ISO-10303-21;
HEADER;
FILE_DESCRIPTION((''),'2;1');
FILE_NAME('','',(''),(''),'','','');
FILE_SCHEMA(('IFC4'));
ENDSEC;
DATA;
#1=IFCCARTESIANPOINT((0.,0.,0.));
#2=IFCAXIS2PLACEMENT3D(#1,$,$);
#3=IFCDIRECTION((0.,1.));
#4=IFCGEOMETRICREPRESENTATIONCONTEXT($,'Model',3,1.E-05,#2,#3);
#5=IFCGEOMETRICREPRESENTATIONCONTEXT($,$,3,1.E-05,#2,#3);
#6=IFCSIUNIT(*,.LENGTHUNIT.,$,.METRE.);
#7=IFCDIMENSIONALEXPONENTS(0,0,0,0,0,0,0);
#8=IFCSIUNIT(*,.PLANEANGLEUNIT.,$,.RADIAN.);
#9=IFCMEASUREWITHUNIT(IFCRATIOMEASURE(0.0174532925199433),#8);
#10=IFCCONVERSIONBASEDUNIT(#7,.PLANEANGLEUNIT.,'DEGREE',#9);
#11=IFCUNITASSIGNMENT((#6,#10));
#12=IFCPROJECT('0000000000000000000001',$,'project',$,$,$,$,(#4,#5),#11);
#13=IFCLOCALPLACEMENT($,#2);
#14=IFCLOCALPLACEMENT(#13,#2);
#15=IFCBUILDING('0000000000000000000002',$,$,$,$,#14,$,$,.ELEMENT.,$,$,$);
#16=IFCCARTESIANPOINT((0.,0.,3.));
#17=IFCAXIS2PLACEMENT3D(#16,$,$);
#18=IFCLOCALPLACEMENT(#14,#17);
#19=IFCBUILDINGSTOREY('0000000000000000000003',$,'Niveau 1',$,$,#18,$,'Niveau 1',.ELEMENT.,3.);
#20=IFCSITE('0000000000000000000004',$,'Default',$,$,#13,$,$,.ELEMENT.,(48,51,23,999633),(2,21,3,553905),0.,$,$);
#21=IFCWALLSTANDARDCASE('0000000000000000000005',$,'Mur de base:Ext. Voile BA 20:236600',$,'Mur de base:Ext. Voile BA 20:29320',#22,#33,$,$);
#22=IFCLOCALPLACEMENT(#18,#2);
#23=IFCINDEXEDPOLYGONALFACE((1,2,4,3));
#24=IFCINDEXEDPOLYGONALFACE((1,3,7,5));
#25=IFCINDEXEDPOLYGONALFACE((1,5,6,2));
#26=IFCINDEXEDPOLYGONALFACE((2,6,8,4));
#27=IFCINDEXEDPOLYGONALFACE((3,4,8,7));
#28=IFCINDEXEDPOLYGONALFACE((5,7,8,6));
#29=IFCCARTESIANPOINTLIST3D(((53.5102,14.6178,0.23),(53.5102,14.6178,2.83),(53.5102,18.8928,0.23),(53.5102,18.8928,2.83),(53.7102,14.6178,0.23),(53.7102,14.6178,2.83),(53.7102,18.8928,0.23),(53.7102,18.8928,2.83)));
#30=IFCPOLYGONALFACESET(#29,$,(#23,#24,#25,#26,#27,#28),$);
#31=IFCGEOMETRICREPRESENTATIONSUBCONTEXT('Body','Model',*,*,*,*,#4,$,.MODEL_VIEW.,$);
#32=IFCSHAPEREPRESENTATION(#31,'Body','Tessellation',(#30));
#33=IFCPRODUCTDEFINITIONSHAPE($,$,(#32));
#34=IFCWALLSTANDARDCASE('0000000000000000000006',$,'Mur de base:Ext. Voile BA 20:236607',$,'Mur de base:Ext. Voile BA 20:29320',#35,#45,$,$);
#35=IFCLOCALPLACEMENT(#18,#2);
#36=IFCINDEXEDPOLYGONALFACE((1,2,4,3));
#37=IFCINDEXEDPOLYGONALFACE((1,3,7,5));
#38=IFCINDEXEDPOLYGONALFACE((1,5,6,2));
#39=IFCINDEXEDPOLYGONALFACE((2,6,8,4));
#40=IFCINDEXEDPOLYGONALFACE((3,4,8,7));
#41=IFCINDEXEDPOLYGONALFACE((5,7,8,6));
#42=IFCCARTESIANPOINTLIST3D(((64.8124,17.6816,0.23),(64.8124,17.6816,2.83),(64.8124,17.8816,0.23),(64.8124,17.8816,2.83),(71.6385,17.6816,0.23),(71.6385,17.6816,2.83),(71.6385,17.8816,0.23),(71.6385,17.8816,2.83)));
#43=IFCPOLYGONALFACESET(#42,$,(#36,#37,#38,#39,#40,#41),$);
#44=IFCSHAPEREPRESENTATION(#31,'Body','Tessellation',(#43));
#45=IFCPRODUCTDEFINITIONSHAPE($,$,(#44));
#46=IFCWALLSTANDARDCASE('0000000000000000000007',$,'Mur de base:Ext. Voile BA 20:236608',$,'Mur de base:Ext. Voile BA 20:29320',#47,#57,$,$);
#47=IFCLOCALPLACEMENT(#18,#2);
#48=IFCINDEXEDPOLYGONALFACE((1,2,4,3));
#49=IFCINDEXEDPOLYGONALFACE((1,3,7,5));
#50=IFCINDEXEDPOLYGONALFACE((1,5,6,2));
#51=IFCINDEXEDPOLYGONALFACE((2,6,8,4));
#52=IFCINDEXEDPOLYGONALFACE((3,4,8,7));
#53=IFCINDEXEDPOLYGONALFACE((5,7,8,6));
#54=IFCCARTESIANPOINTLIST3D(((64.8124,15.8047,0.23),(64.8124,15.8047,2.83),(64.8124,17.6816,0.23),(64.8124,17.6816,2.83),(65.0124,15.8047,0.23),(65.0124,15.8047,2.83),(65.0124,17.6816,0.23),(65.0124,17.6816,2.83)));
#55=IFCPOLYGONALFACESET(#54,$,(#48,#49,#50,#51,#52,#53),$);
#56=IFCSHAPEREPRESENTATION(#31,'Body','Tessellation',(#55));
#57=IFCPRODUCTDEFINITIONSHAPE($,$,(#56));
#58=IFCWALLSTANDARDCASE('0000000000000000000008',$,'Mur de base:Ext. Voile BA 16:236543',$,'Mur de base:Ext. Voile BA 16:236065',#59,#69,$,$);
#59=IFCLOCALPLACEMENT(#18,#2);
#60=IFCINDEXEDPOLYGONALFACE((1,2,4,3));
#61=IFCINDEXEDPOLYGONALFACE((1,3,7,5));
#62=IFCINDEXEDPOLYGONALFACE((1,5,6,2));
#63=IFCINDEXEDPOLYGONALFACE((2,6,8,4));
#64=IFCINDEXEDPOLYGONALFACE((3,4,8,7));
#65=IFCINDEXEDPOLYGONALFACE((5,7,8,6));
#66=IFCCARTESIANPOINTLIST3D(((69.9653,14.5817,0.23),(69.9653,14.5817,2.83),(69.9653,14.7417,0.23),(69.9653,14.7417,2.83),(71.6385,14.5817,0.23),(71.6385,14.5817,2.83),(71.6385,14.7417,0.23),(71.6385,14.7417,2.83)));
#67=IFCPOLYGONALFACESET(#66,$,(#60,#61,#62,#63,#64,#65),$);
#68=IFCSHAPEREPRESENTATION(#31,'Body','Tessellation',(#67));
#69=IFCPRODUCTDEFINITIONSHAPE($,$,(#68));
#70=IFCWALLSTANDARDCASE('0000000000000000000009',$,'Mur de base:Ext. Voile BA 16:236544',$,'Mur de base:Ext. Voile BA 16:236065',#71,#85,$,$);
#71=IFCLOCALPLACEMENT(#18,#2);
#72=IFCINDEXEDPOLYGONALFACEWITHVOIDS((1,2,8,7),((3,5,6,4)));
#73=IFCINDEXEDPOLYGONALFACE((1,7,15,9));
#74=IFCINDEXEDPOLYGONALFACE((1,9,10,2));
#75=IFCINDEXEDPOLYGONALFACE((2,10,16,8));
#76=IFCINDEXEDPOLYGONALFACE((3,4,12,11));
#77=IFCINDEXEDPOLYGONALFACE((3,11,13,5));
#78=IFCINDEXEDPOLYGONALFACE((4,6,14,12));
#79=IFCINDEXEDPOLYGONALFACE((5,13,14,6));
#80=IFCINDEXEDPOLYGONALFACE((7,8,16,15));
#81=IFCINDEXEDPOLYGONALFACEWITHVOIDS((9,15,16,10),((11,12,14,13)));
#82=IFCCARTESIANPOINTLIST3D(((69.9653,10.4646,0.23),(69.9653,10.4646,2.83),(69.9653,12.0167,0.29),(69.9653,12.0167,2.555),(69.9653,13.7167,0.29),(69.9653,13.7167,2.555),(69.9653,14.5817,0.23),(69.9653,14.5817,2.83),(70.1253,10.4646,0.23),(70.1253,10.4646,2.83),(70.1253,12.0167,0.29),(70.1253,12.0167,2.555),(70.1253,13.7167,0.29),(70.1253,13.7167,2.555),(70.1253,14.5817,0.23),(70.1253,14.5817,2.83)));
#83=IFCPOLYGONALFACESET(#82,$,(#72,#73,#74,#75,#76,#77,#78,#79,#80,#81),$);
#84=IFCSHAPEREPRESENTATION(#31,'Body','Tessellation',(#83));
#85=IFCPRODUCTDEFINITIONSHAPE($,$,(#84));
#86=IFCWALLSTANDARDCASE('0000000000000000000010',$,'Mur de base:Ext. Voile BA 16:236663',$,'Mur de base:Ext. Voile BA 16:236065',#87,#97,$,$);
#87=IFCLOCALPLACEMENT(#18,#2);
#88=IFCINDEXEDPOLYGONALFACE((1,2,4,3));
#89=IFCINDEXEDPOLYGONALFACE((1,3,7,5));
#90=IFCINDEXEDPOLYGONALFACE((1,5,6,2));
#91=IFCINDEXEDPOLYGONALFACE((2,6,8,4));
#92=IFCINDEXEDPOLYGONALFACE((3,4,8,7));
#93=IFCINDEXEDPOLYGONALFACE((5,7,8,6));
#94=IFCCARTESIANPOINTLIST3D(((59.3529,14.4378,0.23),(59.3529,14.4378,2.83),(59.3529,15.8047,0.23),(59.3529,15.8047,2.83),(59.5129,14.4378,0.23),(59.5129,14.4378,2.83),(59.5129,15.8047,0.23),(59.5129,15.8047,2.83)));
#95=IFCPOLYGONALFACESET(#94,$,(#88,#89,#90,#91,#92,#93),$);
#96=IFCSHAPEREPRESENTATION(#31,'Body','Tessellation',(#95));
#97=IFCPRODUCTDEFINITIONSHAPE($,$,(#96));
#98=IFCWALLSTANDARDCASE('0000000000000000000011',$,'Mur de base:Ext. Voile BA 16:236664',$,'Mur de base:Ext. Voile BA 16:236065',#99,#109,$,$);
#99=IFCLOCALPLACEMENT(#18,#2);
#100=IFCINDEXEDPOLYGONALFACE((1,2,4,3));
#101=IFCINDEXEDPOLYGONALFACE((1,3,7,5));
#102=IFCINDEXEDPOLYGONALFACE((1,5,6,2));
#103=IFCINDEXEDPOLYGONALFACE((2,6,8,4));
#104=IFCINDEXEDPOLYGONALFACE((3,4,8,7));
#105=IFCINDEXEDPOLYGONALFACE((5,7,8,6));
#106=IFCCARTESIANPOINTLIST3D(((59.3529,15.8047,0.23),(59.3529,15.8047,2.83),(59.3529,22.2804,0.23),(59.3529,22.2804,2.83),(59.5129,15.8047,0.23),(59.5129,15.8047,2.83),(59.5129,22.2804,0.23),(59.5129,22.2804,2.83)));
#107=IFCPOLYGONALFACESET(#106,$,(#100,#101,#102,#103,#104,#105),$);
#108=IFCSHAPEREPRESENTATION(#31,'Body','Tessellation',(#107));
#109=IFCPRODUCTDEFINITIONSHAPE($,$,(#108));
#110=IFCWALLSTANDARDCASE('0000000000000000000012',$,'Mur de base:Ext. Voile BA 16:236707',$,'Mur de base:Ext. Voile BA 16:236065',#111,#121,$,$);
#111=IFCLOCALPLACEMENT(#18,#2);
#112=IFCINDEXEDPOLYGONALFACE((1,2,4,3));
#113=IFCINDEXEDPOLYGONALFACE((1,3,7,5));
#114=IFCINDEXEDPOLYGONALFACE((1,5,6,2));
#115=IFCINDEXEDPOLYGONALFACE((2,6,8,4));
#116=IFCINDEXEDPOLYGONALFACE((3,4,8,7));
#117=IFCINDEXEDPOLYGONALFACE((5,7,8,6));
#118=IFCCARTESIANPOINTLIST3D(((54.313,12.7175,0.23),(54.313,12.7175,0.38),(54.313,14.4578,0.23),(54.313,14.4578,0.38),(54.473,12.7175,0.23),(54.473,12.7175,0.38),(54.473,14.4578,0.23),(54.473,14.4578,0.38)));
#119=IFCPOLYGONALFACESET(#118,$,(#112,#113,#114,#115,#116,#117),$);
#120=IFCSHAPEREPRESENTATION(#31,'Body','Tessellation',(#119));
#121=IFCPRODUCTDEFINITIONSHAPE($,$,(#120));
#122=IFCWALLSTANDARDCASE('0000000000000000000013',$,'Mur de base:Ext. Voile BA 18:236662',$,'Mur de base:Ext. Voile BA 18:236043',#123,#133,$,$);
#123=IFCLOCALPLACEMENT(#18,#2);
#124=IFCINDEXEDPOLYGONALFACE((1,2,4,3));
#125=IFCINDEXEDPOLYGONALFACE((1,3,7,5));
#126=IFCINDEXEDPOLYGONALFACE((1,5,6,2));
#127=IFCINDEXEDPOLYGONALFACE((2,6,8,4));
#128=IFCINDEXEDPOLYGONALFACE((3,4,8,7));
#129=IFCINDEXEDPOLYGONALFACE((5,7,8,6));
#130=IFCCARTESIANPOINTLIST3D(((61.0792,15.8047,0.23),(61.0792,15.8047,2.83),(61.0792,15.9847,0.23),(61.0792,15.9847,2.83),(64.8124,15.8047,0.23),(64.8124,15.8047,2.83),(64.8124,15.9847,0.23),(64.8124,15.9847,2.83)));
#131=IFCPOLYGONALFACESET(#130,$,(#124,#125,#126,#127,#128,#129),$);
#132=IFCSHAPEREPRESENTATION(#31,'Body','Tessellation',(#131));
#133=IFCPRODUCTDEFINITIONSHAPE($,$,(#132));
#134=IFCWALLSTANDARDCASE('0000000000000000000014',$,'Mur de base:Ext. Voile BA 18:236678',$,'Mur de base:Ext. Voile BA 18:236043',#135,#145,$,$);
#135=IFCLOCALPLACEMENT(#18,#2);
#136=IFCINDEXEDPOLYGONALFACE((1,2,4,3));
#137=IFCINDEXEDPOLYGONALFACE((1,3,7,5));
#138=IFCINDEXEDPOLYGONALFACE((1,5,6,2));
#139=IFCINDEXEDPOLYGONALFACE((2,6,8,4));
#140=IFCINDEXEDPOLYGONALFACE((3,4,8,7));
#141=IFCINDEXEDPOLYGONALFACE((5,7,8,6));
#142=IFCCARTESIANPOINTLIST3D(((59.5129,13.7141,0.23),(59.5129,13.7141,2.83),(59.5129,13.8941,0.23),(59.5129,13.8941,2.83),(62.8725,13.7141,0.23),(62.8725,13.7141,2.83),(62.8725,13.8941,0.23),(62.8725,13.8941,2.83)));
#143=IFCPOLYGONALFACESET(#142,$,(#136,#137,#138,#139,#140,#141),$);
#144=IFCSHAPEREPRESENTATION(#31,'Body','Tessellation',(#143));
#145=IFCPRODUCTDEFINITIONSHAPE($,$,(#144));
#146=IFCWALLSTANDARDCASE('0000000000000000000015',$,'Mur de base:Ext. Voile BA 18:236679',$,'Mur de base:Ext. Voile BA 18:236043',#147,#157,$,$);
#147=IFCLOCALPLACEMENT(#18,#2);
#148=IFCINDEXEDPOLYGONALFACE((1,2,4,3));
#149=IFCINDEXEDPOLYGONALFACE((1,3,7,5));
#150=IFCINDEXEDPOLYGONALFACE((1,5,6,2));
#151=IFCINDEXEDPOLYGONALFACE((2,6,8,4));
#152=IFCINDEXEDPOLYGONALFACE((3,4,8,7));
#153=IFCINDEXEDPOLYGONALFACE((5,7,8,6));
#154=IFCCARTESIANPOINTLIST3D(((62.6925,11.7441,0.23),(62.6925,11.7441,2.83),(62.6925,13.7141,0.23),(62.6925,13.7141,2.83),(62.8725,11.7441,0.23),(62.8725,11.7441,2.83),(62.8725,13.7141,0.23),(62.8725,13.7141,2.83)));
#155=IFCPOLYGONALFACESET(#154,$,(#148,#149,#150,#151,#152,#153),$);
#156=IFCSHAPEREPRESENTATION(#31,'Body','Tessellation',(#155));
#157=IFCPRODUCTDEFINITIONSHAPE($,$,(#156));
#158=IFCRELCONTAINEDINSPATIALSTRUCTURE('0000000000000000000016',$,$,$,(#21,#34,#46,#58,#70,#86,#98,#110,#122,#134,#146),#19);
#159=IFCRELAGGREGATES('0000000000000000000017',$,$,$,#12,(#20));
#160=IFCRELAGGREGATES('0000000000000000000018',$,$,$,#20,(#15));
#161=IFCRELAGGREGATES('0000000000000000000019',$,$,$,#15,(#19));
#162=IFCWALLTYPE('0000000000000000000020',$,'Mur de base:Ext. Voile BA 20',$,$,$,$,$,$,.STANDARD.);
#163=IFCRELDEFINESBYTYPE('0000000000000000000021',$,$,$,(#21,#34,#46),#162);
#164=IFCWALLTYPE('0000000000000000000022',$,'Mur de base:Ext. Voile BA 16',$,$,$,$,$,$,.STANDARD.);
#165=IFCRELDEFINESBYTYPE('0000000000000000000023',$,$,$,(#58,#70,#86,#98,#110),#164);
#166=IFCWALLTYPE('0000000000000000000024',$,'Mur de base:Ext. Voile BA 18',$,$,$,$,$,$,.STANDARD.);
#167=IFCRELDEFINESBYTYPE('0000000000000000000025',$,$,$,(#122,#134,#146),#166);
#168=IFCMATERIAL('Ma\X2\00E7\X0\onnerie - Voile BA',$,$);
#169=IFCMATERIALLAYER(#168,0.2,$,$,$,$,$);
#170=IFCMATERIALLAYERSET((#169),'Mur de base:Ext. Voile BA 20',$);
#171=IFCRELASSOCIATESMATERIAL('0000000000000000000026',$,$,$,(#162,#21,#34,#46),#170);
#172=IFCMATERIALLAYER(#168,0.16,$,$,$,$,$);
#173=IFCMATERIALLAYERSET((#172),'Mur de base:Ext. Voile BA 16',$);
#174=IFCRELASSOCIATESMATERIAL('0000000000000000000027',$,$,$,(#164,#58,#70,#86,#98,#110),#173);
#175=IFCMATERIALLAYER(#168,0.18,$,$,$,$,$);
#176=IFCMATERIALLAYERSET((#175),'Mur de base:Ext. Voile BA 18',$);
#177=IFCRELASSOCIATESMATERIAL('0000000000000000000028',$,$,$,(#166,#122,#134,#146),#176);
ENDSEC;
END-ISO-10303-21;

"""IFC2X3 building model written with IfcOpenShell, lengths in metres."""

from ifc_helpers import new_model, entity, si_unit, converted_unit, direction, frame, frame_2d, origin, origin_2d_with_axis, place, context, subcontext, project, spatial, rectangle, extrude, material, layer, layer_set, layer_usage, type_object, element, save


model = new_model("IFC2X3")

# Units and contexts
model_context = context("Model", 3, precision=1e-05, world=origin(), true_north=direction((0.0, 1.0)))
context_of_model = context(None, 3, precision=1e-05, world=origin(), true_north=direction((0.0, 1.0)))
body_context = subcontext(model_context, "Body", "Model", "MODEL_VIEW")
ifc_project = project(units=[si_unit("LENGTHUNIT", "METRE"), converted_unit("PLANEANGLEUNIT", "DEGREE", entity("IfcRatioMeasure", 0.0174532925199433), si_unit("PLANEANGLEUNIT", "RADIAN"), dimensions=[0, 0, 0, 0, 0, 0, 0])], contexts=[model_context, context_of_model])

# Site, building, storey
site_placement = place(None, origin())
site = spatial("IfcSite", under=ifc_project, at=site_placement, Name="Default", CompositionType="ELEMENT", RefLatitude=(48, 51, 23, 999633), RefLongitude=(2, 21, 3, 553905), RefElevation=0.0)
building_placement = place(site_placement, origin())
building = spatial("IfcBuilding", under=site, at=building_placement, CompositionType="ELEMENT")
storey_placement = place(building_placement, frame((0.0, 0.0, 3.0)))
storey = spatial("IfcBuildingStorey", under=building, at=storey_placement, Name="Niveau 1", LongName="Niveau 1", CompositionType="ELEMENT", Elevation=3.0)

# Walls
ifc_material = material(Name="Maçonnerie - Voile BA")
ifc_layer_1 = layer(ifc_material, 0.2)
ifc_layer_set_1 = layer_set([ifc_layer_1], Name="Mur de base:Ext. Voile BA 20")
ifc_layer_usage_1 = layer_usage(ifc_layer_set_1, "AXIS2", "NEGATIVE", 0.1)
wall_type_1 = type_object("IfcWallType", Name="Mur de base:Ext. Voile BA 20", PredefinedType="STANDARD", material=ifc_layer_set_1)
wall_1_placement = place(storey_placement, frame((53.6102, 18.8928, 0.23), z_axis=(0.0, 0.0, 1.0), x_axis=(0.0, -1.0, 0.0)))
element("IfcWallStandardCase", 1, at=wall_1_placement, inside=storey, type_object=wall_type_1, material=ifc_layer_usage_1, Name="Mur de base:Ext. Voile BA 20:236600", ObjectType="Mur de base:Ext. Voile BA 20:29320", context=body_context, shape_type="SweptSolid", body=[
    extrude(rectangle(XDim=4.275, YDim=0.2, at=frame_2d((2.1375, 0.0), x_axis=(-1.0, 0.0))), origin(), (0.0, 0.0, 1.0), 2.6),
])
ifc_layer_usage_2 = layer_usage(ifc_layer_set_1, "AXIS2", "NEGATIVE", 0.1)
wall_2_placement = place(storey_placement, frame((71.6385, 17.7816, 0.23), z_axis=(0.0, 0.0, 1.0), x_axis=(-1.0, 0.0, 0.0)))
element("IfcWallStandardCase", 2, at=wall_2_placement, inside=storey, type_object=wall_type_1, material=ifc_layer_usage_2, Name="Mur de base:Ext. Voile BA 20:236607", ObjectType="Mur de base:Ext. Voile BA 20:29320", context=body_context, shape_type="SweptSolid", body=[
    extrude(rectangle(XDim=6.8261, YDim=0.2, at=frame_2d((3.4131, 0.0), x_axis=(-1.0, 0.0))), origin(), (0.0, 0.0, 1.0), 2.6),
])
ifc_layer_usage_3 = layer_usage(ifc_layer_set_1, "AXIS2", "NEGATIVE", 0.1)
wall_3_placement = place(storey_placement, frame((64.9124, 17.6816, 0.23), z_axis=(0.0, 0.0, 1.0), x_axis=(0.0, -1.0, 0.0)))
element("IfcWallStandardCase", 3, at=wall_3_placement, inside=storey, type_object=wall_type_1, material=ifc_layer_usage_3, Name="Mur de base:Ext. Voile BA 20:236608", ObjectType="Mur de base:Ext. Voile BA 20:29320", context=body_context, shape_type="SweptSolid", body=[
    extrude(rectangle(XDim=1.8769, YDim=0.2, at=frame_2d((0.9384, 0.0), x_axis=(-1.0, 0.0))), origin(), (0.0, 0.0, 1.0), 2.6),
])

# Wall
ifc_layer_2 = layer(ifc_material, 0.16)
ifc_layer_set_2 = layer_set([ifc_layer_2], Name="Mur de base:Ext. Voile BA 16")
ifc_layer_usage_4 = layer_usage(ifc_layer_set_2, "AXIS2", "NEGATIVE", 0.08)
wall_type_2 = type_object("IfcWallType", Name="Mur de base:Ext. Voile BA 16", PredefinedType="STANDARD", material=ifc_layer_set_2)
wall_4_placement = place(storey_placement, frame((71.6385, 14.6617, 0.23), z_axis=(0.0, 0.0, 1.0), x_axis=(-1.0, 0.0, 0.0)))
element("IfcWallStandardCase", 4, at=wall_4_placement, inside=storey, type_object=wall_type_2, material=ifc_layer_usage_4, Name="Mur de base:Ext. Voile BA 16:236543", ObjectType="Mur de base:Ext. Voile BA 16:236065", context=body_context, shape_type="SweptSolid", body=[
    extrude(rectangle(XDim=1.6732, YDim=0.16, at=frame_2d((0.8366, 0.0), x_axis=(-1.0, 0.0))), origin(), (0.0, 0.0, 1.0), 2.6),
])

# Wall, opening
ifc_layer_usage_5 = layer_usage(ifc_layer_set_2, "AXIS2", "NEGATIVE", 0.08)
wall_5_placement = place(storey_placement, frame((70.0453, 14.5817, 0.23), z_axis=(0.0, 0.0, 1.0), x_axis=(0.0, -1.0, 0.0)))
wall_5 = element("IfcWallStandardCase", 5, at=wall_5_placement, inside=storey, type_object=wall_type_2, material=ifc_layer_usage_5, Name="Mur de base:Ext. Voile BA 16:236544", ObjectType="Mur de base:Ext. Voile BA 16:236065", context=body_context, shape_type="SweptSolid", body=[
    extrude(rectangle(XDim=4.117, YDim=0.16, at=frame_2d((2.0585, 0.0), x_axis=(-1.0, 0.0))), origin(), (0.0, 0.0, 1.0), 2.6),
])
opening_1_placement = place(wall_5_placement, origin())
element("IfcOpeningElement", 6, at=opening_1_placement, cuts=wall_5, ObjectType="Opening", context=body_context, shape_type="SweptSolid", body=[
    extrude(rectangle(XDim=2.265, YDim=1.7, at=origin_2d_with_axis()), frame((1.715, -0.08, 1.1925), z_axis=(0.0, 1.0, 0.0), x_axis=(0.0, 0.0, -1.0)), (0.0, 0.0, 1.0), 0.16),
])

# Walls
ifc_layer_usage_6 = layer_usage(ifc_layer_set_2, "AXIS2", "NEGATIVE", 0.08)
wall_6_placement = place(storey_placement, frame((59.4329, 14.4378, 0.23), z_axis=(0.0, 0.0, 1.0), x_axis=(0.0, 1.0, 0.0)))
element("IfcWallStandardCase", 7, at=wall_6_placement, inside=storey, type_object=wall_type_2, material=ifc_layer_usage_6, Name="Mur de base:Ext. Voile BA 16:236663", ObjectType="Mur de base:Ext. Voile BA 16:236065", context=body_context, shape_type="SweptSolid", body=[
    extrude(rectangle(XDim=1.3669, YDim=0.16, at=frame_2d((0.6834, 0.0), x_axis=(-1.0, 0.0))), origin(), (0.0, 0.0, 1.0), 2.6),
])
ifc_layer_usage_7 = layer_usage(ifc_layer_set_2, "AXIS2", "NEGATIVE", 0.08)
wall_7_placement = place(storey_placement, frame((59.4329, 15.8047, 0.23), z_axis=(0.0, 0.0, 1.0), x_axis=(0.0, 1.0, 0.0)))
element("IfcWallStandardCase", 8, at=wall_7_placement, inside=storey, type_object=wall_type_2, material=ifc_layer_usage_7, Name="Mur de base:Ext. Voile BA 16:236664", ObjectType="Mur de base:Ext. Voile BA 16:236065", context=body_context, shape_type="SweptSolid", body=[
    extrude(rectangle(XDim=6.4757, YDim=0.16, at=frame_2d((3.2379, 0.0), x_axis=(-1.0, 0.0))), origin(), (0.0, 0.0, 1.0), 2.6),
])
ifc_layer_usage_8 = layer_usage(ifc_layer_set_2, "AXIS2", "POSITIVE", -0.08)
wall_8_placement = place(storey_placement, frame((54.393, 12.7175, 0.23), z_axis=(0.0, 0.0, 1.0), x_axis=(0.0, 1.0, 0.0)))
element("IfcWallStandardCase", 9, at=wall_8_placement, inside=storey, type_object=wall_type_2, material=ifc_layer_usage_8, Name="Mur de base:Ext. Voile BA 16:236707", ObjectType="Mur de base:Ext. Voile BA 16:236065", context=body_context, shape_type="SweptSolid", body=[
    extrude(rectangle(XDim=1.7403, YDim=0.16, at=frame_2d((0.8702, 0.0), x_axis=(-1.0, 0.0))), origin(), (0.0, 0.0, 1.0), 0.15),
])
ifc_layer_3 = layer(ifc_material, 0.18)
ifc_layer_set_3 = layer_set([ifc_layer_3], Name="Mur de base:Ext. Voile BA 18")
ifc_layer_usage_9 = layer_usage(ifc_layer_set_3, "AXIS2", "POSITIVE", -0.09)
wall_type_3 = type_object("IfcWallType", Name="Mur de base:Ext. Voile BA 18", PredefinedType="STANDARD", material=ifc_layer_set_3)
wall_9_placement = place(storey_placement, frame((61.0792, 15.8947, 0.23)))
element("IfcWallStandardCase", 10, at=wall_9_placement, inside=storey, type_object=wall_type_3, material=ifc_layer_usage_9, Name="Mur de base:Ext. Voile BA 18:236662", ObjectType="Mur de base:Ext. Voile BA 18:236043", context=body_context, shape_type="SweptSolid", body=[
    extrude(rectangle(XDim=3.7331, YDim=0.18, at=frame_2d((1.8666, 0.0), x_axis=(-1.0, 0.0))), origin(), (0.0, 0.0, 1.0), 2.6),
])
ifc_layer_usage_10 = layer_usage(ifc_layer_set_3, "AXIS2", "NEGATIVE", 0.09)
wall_10_placement = place(storey_placement, frame((59.5129, 13.8041, 0.23)))
element("IfcWallStandardCase", 11, at=wall_10_placement, inside=storey, type_object=wall_type_3, material=ifc_layer_usage_10, Name="Mur de base:Ext. Voile BA 18:236678", ObjectType="Mur de base:Ext. Voile BA 18:236043", context=body_context, shape_type="SweptSolid", body=[
    extrude(rectangle(XDim=3.3596, YDim=0.18, at=frame_2d((1.6798, 0.0), x_axis=(-1.0, 0.0))), origin(), (0.0, 0.0, 1.0), 2.6),
])
ifc_layer_usage_11 = layer_usage(ifc_layer_set_3, "AXIS2", "NEGATIVE", 0.09)
wall_11_placement = place(storey_placement, frame((62.7825, 13.7141, 0.23), z_axis=(0.0, 0.0, 1.0), x_axis=(0.0, -1.0, 0.0)))
element("IfcWallStandardCase", 12, at=wall_11_placement, inside=storey, type_object=wall_type_3, material=ifc_layer_usage_11, Name="Mur de base:Ext. Voile BA 18:236679", ObjectType="Mur de base:Ext. Voile BA 18:236043", context=body_context, shape_type="SweptSolid", body=[
    extrude(rectangle(XDim=1.97, YDim=0.18, at=frame_2d((0.985, 0.0), x_axis=(-1.0, 0.0))), origin(), (0.0, 0.0, 1.0), 2.6),
])

save(model, "model.ifc")
